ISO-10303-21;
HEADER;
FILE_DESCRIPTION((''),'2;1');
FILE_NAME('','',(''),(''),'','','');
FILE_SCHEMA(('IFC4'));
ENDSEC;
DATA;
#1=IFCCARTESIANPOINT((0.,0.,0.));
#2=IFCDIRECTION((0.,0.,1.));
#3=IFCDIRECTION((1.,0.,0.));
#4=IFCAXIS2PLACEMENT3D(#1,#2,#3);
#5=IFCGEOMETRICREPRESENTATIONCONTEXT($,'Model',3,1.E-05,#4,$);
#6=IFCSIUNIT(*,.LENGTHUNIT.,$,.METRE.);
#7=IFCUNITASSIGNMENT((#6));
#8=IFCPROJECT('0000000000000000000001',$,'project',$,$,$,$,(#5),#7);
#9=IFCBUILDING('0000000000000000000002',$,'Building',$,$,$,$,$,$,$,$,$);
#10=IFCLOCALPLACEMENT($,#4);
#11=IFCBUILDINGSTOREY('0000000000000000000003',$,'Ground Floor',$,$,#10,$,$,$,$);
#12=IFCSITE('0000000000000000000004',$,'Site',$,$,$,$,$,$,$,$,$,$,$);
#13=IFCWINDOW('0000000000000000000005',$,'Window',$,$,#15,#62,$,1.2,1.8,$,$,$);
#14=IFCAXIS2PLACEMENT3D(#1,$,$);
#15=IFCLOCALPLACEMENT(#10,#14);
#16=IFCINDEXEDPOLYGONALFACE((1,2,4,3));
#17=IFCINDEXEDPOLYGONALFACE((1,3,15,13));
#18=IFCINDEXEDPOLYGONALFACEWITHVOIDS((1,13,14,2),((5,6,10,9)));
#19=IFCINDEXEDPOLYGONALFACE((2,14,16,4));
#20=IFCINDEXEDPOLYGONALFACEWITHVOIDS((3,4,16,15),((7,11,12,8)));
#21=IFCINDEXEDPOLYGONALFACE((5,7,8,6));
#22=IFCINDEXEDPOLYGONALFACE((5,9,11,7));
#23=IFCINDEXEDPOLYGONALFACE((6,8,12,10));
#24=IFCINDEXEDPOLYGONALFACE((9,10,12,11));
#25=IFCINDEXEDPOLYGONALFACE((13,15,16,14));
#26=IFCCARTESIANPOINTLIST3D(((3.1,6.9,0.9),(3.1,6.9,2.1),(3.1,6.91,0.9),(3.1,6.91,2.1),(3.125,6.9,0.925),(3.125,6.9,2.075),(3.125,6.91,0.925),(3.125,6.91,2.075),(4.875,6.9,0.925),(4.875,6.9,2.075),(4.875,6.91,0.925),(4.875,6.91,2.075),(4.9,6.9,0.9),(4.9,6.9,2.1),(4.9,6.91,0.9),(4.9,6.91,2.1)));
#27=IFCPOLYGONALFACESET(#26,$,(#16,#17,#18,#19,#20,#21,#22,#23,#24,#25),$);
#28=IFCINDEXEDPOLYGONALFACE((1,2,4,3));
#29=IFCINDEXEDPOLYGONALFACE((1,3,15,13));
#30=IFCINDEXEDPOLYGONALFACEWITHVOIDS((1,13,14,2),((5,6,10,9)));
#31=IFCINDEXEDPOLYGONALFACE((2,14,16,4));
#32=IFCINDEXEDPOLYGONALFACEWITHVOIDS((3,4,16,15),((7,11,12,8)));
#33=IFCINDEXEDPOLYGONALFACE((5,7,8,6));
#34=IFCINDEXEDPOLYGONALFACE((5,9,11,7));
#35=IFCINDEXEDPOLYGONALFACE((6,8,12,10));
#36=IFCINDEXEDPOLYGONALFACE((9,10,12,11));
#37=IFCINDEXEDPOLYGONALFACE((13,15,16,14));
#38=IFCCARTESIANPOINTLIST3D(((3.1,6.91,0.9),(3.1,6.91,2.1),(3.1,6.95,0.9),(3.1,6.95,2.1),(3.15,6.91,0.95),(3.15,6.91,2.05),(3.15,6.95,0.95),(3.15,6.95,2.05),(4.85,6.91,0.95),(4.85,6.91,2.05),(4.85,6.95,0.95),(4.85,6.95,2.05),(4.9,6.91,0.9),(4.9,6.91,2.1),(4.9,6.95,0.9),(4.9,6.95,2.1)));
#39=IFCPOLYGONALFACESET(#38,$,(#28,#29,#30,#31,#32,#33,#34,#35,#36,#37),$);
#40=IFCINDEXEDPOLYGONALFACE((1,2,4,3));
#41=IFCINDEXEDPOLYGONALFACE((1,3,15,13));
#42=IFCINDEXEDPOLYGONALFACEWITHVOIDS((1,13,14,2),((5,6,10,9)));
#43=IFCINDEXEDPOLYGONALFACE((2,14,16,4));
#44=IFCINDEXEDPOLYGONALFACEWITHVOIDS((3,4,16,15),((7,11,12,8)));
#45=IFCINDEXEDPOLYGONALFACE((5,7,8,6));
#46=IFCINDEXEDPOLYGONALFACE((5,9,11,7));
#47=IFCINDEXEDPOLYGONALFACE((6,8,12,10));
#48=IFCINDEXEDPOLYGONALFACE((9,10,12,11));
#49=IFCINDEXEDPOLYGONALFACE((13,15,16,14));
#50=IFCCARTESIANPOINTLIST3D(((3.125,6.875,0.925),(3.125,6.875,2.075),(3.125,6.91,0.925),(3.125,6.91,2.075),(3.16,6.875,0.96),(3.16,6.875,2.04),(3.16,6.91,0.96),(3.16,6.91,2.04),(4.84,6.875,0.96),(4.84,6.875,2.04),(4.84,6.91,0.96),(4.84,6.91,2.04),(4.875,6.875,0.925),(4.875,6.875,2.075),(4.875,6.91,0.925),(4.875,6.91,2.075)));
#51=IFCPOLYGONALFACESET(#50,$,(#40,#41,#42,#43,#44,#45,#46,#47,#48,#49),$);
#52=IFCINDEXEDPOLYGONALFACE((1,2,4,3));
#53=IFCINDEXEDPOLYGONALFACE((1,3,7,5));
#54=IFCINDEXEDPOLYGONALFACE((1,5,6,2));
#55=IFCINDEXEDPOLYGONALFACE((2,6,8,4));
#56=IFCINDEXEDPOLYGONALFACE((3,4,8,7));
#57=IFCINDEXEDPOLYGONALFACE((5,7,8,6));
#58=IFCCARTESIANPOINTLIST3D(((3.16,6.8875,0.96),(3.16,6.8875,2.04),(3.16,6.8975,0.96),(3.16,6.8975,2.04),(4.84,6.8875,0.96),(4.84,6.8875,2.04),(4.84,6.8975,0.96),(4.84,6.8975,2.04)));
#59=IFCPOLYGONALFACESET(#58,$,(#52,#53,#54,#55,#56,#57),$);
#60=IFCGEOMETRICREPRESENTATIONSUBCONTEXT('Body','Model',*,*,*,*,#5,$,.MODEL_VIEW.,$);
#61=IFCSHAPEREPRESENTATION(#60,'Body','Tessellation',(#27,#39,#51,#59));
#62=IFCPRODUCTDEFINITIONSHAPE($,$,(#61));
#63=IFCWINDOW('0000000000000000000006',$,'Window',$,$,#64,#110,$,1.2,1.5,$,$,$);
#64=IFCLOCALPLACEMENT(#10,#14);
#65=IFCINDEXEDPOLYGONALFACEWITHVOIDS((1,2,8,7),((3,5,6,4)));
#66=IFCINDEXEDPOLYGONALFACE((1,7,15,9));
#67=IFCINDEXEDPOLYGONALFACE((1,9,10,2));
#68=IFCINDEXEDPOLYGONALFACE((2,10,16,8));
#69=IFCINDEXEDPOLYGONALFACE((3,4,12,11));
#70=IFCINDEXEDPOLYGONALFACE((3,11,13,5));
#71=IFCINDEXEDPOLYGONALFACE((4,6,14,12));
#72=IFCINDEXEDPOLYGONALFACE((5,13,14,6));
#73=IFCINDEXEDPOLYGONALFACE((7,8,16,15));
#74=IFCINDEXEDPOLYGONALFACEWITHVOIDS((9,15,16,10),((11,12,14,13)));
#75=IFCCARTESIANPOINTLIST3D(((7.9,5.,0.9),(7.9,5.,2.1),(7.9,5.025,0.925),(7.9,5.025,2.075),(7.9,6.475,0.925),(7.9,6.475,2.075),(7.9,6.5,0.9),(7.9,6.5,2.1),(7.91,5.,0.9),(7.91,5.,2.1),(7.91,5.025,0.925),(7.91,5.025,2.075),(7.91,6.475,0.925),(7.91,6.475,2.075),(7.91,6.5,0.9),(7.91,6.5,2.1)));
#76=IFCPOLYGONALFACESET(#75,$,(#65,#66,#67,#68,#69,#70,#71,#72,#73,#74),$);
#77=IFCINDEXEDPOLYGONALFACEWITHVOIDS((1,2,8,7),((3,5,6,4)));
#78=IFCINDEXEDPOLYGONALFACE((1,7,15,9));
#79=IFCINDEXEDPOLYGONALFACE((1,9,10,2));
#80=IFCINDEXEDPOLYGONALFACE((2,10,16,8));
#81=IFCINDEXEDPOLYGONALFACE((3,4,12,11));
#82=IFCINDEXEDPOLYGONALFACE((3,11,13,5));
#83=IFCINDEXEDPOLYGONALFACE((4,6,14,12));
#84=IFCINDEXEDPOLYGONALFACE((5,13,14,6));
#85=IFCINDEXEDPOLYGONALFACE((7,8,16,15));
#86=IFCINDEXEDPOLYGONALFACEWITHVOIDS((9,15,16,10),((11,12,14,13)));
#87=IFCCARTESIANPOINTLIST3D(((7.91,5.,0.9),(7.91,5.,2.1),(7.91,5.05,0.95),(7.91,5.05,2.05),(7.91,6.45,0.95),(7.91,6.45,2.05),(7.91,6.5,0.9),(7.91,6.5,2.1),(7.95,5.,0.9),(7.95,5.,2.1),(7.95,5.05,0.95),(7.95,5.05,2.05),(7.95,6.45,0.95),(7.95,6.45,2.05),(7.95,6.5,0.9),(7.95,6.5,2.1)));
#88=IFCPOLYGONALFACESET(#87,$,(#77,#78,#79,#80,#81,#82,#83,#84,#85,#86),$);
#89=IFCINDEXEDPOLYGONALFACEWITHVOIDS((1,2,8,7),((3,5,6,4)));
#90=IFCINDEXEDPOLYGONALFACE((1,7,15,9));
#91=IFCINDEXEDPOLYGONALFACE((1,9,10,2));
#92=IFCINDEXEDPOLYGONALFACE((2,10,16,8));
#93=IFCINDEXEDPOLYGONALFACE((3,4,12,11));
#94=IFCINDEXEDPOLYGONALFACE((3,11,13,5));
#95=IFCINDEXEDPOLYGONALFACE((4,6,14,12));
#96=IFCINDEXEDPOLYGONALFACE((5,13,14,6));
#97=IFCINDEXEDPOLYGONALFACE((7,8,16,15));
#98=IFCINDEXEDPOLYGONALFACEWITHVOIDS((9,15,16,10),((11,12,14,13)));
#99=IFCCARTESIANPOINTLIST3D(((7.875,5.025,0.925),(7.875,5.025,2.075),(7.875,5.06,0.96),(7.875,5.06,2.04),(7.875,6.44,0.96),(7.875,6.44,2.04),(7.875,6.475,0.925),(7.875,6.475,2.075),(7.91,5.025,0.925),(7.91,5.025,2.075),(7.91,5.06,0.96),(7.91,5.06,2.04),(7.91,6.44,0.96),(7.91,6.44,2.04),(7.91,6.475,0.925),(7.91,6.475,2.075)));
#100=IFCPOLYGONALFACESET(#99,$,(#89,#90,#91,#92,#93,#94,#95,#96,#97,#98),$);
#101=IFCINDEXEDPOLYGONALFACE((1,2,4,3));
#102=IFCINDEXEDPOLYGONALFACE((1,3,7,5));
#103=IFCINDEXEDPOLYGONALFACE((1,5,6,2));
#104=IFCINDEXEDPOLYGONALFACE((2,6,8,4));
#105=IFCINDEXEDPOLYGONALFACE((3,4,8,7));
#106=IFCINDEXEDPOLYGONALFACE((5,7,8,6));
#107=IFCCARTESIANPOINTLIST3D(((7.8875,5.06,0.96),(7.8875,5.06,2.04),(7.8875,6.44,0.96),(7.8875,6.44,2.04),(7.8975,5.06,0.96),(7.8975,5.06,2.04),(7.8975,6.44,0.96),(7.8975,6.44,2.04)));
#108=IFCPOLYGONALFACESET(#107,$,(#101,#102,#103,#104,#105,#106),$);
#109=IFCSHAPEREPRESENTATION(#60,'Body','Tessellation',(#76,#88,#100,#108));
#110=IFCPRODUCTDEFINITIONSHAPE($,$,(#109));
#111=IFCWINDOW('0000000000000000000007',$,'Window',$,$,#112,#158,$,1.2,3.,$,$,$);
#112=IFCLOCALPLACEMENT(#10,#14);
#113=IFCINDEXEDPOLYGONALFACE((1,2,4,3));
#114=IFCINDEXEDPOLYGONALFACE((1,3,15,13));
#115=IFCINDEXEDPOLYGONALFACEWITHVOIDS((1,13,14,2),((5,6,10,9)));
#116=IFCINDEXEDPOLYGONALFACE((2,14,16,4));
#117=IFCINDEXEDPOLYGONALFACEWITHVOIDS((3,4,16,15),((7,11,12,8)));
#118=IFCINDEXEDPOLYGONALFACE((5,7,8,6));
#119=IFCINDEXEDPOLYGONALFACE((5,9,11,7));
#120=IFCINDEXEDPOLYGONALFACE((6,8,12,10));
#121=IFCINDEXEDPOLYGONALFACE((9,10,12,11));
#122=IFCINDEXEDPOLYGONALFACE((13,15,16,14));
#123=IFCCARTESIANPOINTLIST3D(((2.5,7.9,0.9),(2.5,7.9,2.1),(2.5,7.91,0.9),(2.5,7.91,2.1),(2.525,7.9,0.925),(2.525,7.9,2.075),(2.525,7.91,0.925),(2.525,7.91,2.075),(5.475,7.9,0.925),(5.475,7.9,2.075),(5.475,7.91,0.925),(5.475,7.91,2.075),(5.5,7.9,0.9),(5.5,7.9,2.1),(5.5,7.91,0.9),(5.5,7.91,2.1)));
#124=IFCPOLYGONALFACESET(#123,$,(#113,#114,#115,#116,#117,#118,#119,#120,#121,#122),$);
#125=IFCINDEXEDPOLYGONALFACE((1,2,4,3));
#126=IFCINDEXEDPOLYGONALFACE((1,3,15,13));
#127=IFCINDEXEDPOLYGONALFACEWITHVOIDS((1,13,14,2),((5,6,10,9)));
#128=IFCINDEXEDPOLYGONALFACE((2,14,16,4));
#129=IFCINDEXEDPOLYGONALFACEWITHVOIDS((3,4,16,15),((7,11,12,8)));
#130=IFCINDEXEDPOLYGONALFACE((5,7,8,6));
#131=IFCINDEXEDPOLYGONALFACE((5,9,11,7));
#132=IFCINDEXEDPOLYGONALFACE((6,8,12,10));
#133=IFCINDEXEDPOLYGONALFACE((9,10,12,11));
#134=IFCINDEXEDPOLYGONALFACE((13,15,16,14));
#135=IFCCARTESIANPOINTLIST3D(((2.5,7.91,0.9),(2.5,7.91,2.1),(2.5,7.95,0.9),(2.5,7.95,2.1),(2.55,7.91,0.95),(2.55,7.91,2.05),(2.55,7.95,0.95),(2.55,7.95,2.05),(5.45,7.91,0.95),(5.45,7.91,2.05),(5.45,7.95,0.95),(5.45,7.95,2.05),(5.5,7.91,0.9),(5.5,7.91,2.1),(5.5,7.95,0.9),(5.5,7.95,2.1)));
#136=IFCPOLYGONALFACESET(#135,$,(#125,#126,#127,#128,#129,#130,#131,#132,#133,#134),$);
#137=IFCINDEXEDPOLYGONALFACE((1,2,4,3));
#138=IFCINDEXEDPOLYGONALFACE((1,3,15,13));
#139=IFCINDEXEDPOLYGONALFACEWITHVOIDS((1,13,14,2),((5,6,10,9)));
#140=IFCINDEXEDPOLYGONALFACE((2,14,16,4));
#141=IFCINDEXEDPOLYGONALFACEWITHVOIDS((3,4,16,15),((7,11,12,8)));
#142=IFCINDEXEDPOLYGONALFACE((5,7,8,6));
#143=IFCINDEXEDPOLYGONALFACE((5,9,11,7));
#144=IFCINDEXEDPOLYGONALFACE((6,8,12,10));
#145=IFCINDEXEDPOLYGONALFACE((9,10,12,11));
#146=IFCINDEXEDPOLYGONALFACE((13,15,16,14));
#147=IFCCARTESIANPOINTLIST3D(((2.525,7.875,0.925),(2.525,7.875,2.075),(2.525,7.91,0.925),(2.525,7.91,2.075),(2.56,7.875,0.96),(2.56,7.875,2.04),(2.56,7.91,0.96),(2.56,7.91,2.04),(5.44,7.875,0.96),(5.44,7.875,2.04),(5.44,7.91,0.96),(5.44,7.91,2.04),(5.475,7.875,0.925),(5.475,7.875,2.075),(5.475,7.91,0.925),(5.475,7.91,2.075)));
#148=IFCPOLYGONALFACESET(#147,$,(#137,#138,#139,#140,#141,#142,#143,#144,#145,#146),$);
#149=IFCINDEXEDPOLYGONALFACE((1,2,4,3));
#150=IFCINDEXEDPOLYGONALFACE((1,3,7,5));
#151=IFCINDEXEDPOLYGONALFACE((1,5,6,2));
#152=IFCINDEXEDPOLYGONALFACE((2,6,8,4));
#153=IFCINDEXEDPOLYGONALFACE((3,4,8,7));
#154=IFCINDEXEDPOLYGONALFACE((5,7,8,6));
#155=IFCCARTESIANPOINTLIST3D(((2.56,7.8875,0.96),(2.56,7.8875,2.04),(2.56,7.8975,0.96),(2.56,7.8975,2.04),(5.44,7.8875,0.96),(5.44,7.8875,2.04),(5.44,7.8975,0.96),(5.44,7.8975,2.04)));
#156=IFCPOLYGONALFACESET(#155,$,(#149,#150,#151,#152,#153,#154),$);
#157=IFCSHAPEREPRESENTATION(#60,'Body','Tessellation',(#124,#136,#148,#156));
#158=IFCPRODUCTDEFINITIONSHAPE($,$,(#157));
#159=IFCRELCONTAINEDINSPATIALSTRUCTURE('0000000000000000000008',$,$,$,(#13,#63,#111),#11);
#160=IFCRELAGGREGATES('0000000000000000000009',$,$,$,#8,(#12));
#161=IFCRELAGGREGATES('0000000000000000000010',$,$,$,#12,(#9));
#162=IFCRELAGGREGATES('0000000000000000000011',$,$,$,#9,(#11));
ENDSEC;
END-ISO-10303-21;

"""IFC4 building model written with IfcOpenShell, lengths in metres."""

from ifc_helpers import new_model, si_unit, frame, origin_with_axes, place, context, subcontext, project, spatial, line, indexed_curve, outline, extrude, element, save


model = new_model("IFC4")

# Units and contexts
model_context = context("Model", 3, precision=1e-05, world=origin_with_axes())
body_context = subcontext(model_context, "Body", "Model", "MODEL_VIEW")
ifc_project = project(units=[si_unit("LENGTHUNIT", "METRE")], contexts=[model_context])

# Site, building, storey
site = spatial("IfcSite", under=ifc_project, Name="Site")
building = spatial("IfcBuilding", under=site, Name="Building")
storey_placement = place(None, origin_with_axes())
storey = spatial("IfcBuildingStorey", under=building, at=storey_placement, Name="Ground Floor")

# Windows
window_1_placement = place(storey_placement, frame((4.9, 7.0, 0.9), z_axis=(0.0, 0.0, 1.0), x_axis=(-1.0, 0.0, 0.0)))
element("IfcWindow", 1, at=window_1_placement, inside=storey, Name="Window", OverallHeight=1.2, OverallWidth=1.8, context=body_context, shape_type="SweptSolid", body=[
    extrude(outline(indexed_curve([(0.0, 0.0), (1.8, 0.0), (1.8, 1.2), (0.0, 1.2)], segments=[line(1, 2, 3, 4, 1)]), holes=[indexed_curve([(0.025, 0.025), (1.775, 0.025), (1.775, 1.175), (0.025, 1.175)], segments=[line(1, 2, 3, 4, 1)])]), frame((0.0, 0.09, 0.0), z_axis=(0.0, -1.0, 0.0), x_axis=(1.0, 0.0, 0.0)), (0.0, 0.0, -1.0), 0.01),
    extrude(outline(indexed_curve([(0.0, 0.0), (1.8, 0.0), (1.8, 1.2), (0.0, 1.2)], segments=[line(1, 2, 3, 4, 1)]), holes=[indexed_curve([(0.05, 0.05), (1.75, 0.05), (1.75, 1.15), (0.05, 1.15)], segments=[line(1, 2, 3, 4, 1)])]), frame((0.0, 0.05, 0.0), z_axis=(0.0, -1.0, 0.0), x_axis=(1.0, 0.0, 0.0)), (0.0, 0.0, -1.0), 0.04),
    extrude(outline(indexed_curve([(0.0, 0.0), (1.75, 0.0), (1.75, 1.15), (0.0, 1.15)], segments=[line(1, 2, 3, 4, 1)]), holes=[indexed_curve([(0.035, 0.035), (1.715, 0.035), (1.715, 1.115), (0.035, 1.115)], segments=[line(1, 2, 3, 4, 1)])]), frame((0.025, 0.09, 0.025), z_axis=(0.0, -1.0, 0.0), x_axis=(1.0, 0.0, 0.0)), (0.0, 0.0, -1.0), 0.035),
    extrude(outline(indexed_curve([(0.035, 0.035), (1.715, 0.035), (1.715, 1.115), (0.035, 1.115)], segments=[line(1, 2, 3, 4, 1)])), frame((0.025, 0.1025, 0.025), z_axis=(0.0, -1.0, 0.0), x_axis=(1.0, 0.0, 0.0)), (0.0, 0.0, -1.0), 0.01),
])
window_2_placement = place(storey_placement, frame((8.0, 5.0, 0.9), z_axis=(0.0, 0.0, 1.0), x_axis=(0.0, 1.0, 0.0)))
element("IfcWindow", 2, at=window_2_placement, inside=storey, Name="Window", OverallHeight=1.2, OverallWidth=1.5, context=body_context, shape_type="SweptSolid", body=[
    extrude(outline(indexed_curve([(0.0, 0.0), (1.5, 0.0), (1.5, 1.2), (0.0, 1.2)], segments=[line(1, 2, 3, 4, 1)]), holes=[indexed_curve([(0.025, 0.025), (1.475, 0.025), (1.475, 1.175), (0.025, 1.175)], segments=[line(1, 2, 3, 4, 1)])]), frame((0.0, 0.09, 0.0), z_axis=(0.0, -1.0, 0.0), x_axis=(1.0, 0.0, 0.0)), (0.0, 0.0, -1.0), 0.01),
    extrude(outline(indexed_curve([(0.0, 0.0), (1.5, 0.0), (1.5, 1.2), (0.0, 1.2)], segments=[line(1, 2, 3, 4, 1)]), holes=[indexed_curve([(0.05, 0.05), (1.45, 0.05), (1.45, 1.15), (0.05, 1.15)], segments=[line(1, 2, 3, 4, 1)])]), frame((0.0, 0.05, 0.0), z_axis=(0.0, -1.0, 0.0), x_axis=(1.0, 0.0, 0.0)), (0.0, 0.0, -1.0), 0.04),
    extrude(outline(indexed_curve([(0.0, 0.0), (1.45, 0.0), (1.45, 1.15), (0.0, 1.15)], segments=[line(1, 2, 3, 4, 1)]), holes=[indexed_curve([(0.035, 0.035), (1.415, 0.035), (1.415, 1.115), (0.035, 1.115)], segments=[line(1, 2, 3, 4, 1)])]), frame((0.025, 0.09, 0.025), z_axis=(0.0, -1.0, 0.0), x_axis=(1.0, 0.0, 0.0)), (0.0, 0.0, -1.0), 0.035),
    extrude(outline(indexed_curve([(0.035, 0.035), (1.415, 0.035), (1.415, 1.115), (0.035, 1.115)], segments=[line(1, 2, 3, 4, 1)])), frame((0.025, 0.1025, 0.025), z_axis=(0.0, -1.0, 0.0), x_axis=(1.0, 0.0, 0.0)), (0.0, 0.0, -1.0), 0.01),
])
window_3_placement = place(storey_placement, frame((5.5, 8.0, 0.9), z_axis=(0.0, 0.0, 1.0), x_axis=(-1.0, 0.0, 0.0)))
element("IfcWindow", 3, at=window_3_placement, inside=storey, Name="Window", OverallHeight=1.2, OverallWidth=3.0, context=body_context, shape_type="SweptSolid", body=[
    extrude(outline(indexed_curve([(0.0, 0.0), (3.0, 0.0), (3.0, 1.2), (0.0, 1.2)], segments=[line(1, 2, 3, 4, 1)]), holes=[indexed_curve([(0.025, 0.025), (2.975, 0.025), (2.975, 1.175), (0.025, 1.175)], segments=[line(1, 2, 3, 4, 1)])]), frame((0.0, 0.09, 0.0), z_axis=(0.0, -1.0, 0.0), x_axis=(1.0, 0.0, 0.0)), (0.0, 0.0, -1.0), 0.01),
    extrude(outline(indexed_curve([(0.0, 0.0), (3.0, 0.0), (3.0, 1.2), (0.0, 1.2)], segments=[line(1, 2, 3, 4, 1)]), holes=[indexed_curve([(0.05, 0.05), (2.95, 0.05), (2.95, 1.15), (0.05, 1.15)], segments=[line(1, 2, 3, 4, 1)])]), frame((0.0, 0.05, 0.0), z_axis=(0.0, -1.0, 0.0), x_axis=(1.0, 0.0, 0.0)), (0.0, 0.0, -1.0), 0.04),
    extrude(outline(indexed_curve([(0.0, 0.0), (2.95, 0.0), (2.95, 1.15), (0.0, 1.15)], segments=[line(1, 2, 3, 4, 1)]), holes=[indexed_curve([(0.035, 0.035), (2.915, 0.035), (2.915, 1.115), (0.035, 1.115)], segments=[line(1, 2, 3, 4, 1)])]), frame((0.025, 0.09, 0.025), z_axis=(0.0, -1.0, 0.0), x_axis=(1.0, 0.0, 0.0)), (0.0, 0.0, -1.0), 0.035),
    extrude(outline(indexed_curve([(0.035, 0.035), (2.915, 0.035), (2.915, 1.115), (0.035, 1.115)], segments=[line(1, 2, 3, 4, 1)])), frame((0.025, 0.1025, 0.025), z_axis=(0.0, -1.0, 0.0), x_axis=(1.0, 0.0, 0.0)), (0.0, 0.0, -1.0), 0.01),
])

save(model, "model.ifc")
